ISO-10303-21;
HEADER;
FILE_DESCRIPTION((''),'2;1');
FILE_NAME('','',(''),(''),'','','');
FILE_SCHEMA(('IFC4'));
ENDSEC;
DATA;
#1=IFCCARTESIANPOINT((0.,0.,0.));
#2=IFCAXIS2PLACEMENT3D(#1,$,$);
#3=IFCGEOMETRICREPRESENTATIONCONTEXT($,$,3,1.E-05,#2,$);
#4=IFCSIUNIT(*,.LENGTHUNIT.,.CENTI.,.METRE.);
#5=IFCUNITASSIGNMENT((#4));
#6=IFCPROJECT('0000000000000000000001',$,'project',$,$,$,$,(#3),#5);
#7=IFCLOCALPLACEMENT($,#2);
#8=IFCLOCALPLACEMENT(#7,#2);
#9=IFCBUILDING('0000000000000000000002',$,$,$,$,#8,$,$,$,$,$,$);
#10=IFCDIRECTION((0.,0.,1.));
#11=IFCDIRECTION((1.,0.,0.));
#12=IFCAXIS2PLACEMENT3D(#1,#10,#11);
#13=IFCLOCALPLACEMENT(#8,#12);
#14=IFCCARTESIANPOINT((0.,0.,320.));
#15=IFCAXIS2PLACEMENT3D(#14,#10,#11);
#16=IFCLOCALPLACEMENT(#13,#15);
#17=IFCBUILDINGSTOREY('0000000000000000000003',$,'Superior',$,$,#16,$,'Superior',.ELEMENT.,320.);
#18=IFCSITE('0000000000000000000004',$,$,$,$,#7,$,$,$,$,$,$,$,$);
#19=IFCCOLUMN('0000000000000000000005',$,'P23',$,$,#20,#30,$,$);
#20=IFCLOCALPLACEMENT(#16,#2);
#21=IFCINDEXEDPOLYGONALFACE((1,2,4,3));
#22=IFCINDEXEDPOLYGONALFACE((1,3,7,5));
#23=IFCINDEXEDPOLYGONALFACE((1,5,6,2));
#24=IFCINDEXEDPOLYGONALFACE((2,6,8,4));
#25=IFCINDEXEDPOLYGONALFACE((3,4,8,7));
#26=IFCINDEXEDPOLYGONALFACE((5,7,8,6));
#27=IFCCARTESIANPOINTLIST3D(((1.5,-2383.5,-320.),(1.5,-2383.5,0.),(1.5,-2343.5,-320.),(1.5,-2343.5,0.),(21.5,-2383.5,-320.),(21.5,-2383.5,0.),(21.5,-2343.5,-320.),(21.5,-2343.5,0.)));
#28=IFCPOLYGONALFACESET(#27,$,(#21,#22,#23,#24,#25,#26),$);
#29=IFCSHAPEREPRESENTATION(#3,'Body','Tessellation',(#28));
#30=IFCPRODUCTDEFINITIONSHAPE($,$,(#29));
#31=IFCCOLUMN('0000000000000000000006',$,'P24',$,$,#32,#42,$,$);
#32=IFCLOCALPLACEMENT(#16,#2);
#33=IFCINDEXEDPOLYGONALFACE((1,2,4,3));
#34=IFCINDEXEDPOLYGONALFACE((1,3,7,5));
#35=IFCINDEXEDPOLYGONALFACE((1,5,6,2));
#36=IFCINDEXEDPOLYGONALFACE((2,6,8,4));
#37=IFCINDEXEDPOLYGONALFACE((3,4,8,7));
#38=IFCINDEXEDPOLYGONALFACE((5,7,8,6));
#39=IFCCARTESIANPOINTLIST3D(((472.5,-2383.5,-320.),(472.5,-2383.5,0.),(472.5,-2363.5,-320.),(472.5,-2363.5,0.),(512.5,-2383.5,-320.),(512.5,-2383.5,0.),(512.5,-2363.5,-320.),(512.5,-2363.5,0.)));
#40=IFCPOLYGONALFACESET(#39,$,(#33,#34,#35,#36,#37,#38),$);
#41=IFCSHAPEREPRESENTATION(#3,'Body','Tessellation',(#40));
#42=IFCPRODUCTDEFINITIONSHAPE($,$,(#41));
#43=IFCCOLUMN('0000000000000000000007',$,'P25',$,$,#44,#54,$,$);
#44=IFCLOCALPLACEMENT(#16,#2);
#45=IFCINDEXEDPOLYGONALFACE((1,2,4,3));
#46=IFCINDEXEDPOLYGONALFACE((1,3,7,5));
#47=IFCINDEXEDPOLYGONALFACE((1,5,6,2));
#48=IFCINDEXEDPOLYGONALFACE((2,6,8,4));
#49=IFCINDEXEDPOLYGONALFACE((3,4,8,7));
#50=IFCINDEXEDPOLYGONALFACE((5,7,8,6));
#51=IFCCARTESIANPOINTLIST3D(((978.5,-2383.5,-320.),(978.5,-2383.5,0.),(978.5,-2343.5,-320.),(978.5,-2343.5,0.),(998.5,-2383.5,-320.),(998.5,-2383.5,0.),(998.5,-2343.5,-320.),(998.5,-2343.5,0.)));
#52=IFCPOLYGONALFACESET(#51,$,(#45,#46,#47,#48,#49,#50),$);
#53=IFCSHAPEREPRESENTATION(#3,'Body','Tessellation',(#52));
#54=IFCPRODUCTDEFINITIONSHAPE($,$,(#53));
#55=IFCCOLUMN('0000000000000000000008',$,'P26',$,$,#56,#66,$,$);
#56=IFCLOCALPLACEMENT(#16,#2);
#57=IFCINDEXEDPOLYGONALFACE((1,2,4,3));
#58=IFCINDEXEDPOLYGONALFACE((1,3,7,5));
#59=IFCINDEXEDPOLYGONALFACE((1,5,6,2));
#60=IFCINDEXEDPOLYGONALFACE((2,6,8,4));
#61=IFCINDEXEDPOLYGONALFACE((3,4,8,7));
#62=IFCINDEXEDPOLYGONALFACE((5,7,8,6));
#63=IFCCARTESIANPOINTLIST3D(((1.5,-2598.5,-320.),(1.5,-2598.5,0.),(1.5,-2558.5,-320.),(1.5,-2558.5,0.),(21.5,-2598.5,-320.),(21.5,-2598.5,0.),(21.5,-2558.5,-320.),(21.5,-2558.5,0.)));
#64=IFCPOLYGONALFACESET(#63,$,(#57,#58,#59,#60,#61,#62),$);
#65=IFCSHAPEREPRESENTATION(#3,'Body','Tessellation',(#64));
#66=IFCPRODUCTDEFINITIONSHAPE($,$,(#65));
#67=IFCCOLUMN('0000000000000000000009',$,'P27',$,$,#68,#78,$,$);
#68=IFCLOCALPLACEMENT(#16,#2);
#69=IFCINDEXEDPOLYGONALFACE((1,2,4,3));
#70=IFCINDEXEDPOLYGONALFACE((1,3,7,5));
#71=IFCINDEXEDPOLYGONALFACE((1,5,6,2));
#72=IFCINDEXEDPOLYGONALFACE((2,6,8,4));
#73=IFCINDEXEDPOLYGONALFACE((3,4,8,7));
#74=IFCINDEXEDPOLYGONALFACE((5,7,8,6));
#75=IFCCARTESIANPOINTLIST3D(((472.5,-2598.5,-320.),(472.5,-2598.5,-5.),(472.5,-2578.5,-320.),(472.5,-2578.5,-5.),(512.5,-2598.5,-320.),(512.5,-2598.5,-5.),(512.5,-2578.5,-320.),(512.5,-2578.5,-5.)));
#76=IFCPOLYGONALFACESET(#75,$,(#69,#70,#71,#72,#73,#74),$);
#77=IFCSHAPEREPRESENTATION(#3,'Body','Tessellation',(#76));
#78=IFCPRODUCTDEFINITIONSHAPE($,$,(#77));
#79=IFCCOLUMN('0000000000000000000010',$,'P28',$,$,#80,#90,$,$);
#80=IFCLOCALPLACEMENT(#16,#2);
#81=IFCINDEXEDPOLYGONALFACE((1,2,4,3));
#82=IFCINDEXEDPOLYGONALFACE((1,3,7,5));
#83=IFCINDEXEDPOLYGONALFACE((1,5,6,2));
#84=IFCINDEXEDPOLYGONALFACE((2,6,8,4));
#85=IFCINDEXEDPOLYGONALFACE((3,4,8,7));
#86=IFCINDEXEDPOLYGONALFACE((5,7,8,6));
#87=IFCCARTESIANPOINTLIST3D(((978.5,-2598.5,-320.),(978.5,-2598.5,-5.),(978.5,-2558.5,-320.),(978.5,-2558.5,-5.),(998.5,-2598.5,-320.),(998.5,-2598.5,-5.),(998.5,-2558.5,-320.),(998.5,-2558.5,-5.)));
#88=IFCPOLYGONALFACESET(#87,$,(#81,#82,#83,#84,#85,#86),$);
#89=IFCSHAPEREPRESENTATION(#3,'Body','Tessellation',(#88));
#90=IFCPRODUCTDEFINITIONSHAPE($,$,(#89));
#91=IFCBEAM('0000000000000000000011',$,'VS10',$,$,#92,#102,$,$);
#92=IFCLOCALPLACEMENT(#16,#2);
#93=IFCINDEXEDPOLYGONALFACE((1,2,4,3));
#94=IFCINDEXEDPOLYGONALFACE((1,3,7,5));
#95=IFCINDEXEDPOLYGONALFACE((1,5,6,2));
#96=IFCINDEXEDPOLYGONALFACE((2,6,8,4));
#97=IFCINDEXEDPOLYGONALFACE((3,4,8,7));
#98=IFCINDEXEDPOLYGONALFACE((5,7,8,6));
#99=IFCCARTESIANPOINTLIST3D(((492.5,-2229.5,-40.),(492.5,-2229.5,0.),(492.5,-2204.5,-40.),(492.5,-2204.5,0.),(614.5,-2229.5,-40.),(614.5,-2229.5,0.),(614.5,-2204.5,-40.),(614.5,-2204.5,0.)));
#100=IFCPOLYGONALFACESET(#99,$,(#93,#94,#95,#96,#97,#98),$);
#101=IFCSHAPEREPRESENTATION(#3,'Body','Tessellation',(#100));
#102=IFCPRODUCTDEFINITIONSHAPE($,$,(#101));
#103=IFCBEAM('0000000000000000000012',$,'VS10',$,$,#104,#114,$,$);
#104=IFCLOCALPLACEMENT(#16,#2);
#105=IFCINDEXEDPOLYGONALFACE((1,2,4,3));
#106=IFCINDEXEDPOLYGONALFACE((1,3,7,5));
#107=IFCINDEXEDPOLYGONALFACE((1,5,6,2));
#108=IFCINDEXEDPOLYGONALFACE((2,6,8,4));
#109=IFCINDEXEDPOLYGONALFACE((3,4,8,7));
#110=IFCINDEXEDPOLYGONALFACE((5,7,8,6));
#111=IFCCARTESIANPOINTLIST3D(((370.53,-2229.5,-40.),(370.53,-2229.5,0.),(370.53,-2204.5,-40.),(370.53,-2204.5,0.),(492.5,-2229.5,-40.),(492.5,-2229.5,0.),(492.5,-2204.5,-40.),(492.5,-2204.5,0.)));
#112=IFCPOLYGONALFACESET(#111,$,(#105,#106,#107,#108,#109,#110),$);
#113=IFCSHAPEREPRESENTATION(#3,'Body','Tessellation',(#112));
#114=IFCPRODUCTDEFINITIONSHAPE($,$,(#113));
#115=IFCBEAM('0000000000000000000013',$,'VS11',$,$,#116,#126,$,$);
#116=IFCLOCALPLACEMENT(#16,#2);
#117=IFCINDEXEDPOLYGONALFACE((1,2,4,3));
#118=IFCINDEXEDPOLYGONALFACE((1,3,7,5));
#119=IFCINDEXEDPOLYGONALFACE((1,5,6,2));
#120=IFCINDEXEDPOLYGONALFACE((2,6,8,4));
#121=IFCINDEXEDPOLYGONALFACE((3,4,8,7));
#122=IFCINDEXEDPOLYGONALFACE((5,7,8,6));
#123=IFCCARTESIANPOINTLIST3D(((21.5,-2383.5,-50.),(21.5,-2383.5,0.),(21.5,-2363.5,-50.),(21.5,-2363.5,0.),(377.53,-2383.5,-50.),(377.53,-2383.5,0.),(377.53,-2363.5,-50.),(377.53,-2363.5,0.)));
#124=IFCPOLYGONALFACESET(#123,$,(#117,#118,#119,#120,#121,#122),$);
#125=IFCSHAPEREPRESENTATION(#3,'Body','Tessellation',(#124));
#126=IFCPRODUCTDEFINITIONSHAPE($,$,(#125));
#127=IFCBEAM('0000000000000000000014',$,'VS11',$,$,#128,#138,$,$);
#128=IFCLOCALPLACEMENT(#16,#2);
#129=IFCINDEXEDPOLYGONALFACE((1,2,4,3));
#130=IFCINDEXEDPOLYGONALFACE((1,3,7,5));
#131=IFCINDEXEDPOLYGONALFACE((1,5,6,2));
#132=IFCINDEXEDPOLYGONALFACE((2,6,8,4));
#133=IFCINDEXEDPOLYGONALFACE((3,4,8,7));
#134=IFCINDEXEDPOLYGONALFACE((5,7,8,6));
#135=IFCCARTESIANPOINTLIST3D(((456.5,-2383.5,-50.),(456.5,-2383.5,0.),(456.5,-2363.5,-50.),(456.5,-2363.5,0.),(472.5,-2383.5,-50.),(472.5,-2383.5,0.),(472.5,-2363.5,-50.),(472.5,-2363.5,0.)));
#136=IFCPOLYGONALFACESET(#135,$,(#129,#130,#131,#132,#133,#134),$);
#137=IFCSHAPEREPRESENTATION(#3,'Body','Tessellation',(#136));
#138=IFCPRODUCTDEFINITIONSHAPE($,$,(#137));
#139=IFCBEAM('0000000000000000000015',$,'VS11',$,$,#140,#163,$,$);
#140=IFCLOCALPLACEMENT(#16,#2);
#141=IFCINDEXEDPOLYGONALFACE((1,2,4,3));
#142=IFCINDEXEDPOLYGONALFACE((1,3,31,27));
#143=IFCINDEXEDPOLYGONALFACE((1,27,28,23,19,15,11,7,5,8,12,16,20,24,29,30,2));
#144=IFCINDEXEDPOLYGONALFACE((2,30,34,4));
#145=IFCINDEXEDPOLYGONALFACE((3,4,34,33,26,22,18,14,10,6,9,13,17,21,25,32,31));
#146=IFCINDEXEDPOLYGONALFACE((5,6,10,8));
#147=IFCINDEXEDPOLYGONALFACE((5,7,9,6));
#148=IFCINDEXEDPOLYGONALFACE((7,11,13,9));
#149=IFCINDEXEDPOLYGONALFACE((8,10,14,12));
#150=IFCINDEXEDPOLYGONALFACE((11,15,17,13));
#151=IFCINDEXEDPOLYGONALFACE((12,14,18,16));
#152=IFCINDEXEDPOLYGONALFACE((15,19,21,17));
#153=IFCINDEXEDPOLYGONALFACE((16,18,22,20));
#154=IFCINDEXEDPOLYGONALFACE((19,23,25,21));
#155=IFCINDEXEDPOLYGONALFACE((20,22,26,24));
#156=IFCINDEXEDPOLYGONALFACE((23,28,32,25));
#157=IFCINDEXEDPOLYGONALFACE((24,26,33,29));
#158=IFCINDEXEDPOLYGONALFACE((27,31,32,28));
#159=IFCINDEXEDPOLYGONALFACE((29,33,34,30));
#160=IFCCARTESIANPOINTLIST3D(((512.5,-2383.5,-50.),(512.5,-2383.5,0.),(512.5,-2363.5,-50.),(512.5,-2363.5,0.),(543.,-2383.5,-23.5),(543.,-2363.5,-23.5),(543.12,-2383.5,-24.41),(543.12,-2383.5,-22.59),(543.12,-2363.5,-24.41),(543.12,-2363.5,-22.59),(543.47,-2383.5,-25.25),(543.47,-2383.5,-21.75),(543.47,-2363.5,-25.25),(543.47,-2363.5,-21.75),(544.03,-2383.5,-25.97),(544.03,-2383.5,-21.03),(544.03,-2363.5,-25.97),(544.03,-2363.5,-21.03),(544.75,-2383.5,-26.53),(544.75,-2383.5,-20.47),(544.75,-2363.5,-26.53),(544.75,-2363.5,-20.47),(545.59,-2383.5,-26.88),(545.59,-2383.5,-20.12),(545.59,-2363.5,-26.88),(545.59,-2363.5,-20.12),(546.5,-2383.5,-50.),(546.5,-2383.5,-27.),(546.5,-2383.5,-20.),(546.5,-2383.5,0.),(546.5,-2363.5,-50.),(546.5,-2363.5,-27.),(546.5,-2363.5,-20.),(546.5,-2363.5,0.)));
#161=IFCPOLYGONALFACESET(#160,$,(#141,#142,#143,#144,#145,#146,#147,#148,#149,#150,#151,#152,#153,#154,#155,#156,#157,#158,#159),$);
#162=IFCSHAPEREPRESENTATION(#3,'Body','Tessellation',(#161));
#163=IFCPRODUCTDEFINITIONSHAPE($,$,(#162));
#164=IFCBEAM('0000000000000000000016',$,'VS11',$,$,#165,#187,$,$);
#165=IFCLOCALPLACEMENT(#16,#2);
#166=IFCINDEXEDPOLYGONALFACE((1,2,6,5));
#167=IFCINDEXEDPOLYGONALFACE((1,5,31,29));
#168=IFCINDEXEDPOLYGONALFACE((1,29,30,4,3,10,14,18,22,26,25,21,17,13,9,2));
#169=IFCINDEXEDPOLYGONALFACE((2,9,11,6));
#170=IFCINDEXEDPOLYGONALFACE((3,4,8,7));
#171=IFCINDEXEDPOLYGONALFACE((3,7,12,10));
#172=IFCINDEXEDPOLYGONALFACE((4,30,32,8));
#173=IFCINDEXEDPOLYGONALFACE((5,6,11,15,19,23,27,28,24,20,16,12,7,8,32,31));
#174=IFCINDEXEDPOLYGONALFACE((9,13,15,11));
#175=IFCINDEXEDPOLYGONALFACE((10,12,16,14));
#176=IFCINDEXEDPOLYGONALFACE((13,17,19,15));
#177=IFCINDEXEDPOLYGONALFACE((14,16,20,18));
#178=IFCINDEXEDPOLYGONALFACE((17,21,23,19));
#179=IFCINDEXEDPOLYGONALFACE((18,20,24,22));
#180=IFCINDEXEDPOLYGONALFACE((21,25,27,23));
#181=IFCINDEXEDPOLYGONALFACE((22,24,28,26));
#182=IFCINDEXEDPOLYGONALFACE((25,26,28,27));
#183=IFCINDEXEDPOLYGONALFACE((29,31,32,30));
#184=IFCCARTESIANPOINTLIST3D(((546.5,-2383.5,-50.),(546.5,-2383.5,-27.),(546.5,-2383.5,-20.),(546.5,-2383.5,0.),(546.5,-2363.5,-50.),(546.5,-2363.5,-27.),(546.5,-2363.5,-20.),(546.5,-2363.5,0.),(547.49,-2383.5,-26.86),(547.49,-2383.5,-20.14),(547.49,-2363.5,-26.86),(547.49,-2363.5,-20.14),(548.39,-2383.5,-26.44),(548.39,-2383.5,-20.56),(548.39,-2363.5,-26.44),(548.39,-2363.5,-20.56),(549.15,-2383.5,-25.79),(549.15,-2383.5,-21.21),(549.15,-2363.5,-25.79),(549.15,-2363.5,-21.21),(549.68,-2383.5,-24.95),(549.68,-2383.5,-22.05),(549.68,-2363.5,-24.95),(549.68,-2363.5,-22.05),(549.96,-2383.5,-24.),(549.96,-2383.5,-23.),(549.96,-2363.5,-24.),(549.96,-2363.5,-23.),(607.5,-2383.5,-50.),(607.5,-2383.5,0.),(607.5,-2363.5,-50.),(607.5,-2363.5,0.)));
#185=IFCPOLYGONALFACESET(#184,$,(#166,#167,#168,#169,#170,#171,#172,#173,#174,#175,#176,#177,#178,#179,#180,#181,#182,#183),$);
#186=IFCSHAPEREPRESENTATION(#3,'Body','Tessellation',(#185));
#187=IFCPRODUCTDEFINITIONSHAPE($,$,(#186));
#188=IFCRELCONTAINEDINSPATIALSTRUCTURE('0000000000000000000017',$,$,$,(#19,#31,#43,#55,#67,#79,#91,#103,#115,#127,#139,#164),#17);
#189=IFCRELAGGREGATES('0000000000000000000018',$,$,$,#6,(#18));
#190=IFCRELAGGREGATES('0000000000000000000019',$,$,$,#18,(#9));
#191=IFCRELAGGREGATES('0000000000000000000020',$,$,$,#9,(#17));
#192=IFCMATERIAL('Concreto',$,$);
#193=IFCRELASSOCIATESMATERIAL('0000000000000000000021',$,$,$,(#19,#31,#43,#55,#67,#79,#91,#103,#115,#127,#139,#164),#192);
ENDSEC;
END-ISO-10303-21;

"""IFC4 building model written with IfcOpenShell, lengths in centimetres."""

from ifc_helpers import new_model, si_unit, frame, origin, origin_with_axes, origin_2d_with_axis, place, context, project, spatial, polyline, circle, outline, extrude, material, element, save


model = new_model("IFC4")

# Units and contexts
context_of_model = context(None, 3, precision=1e-05, world=origin())
ifc_project = project(units=[si_unit("LENGTHUNIT", "METRE", prefix="CENTI")], contexts=[context_of_model])

# Site, building, storey
site_placement = place(None, origin())
site = spatial("IfcSite", under=ifc_project, at=site_placement)
building_placement = place(site_placement, origin())
building = spatial("IfcBuilding", under=site, at=building_placement)
placement = place(building_placement, origin_with_axes())
storey_placement = place(placement, frame((0.0, 0.0, 320.0), z_axis=(0.0, 0.0, 1.0), x_axis=(1.0, 0.0, 0.0)))
storey = spatial("IfcBuildingStorey", under=building, at=storey_placement, Name="Superior", LongName="Superior", CompositionType="ELEMENT", Elevation=320.0)

# Columns
ifc_material = material(Name="Concreto")
column_1_placement = place(storey_placement, frame((11.5, -2363.5, 0.0), z_axis=(0.0, 0.0, 1.0), x_axis=(1.0, 0.0, 0.0)))
element("IfcColumn", 1, at=column_1_placement, inside=storey, material=ifc_material, Name="P23", context=context_of_model, shape_type="SolidModel", body=[
    extrude(outline(polyline([(-10.0, -20.0), (10.0, -20.0), (10.0, 20.0), (-10.0, 20.0), (-10.0, -20.0)])), frame((0.0, 0.0, 0.0), z_axis=(0.0, 0.0, 1.0), x_axis=(1.0, 0.0, 0.0)), (0.0, 0.0, -1.0), 320.0),
])
column_2_placement = place(storey_placement, frame((492.5, -2373.5, 0.0), z_axis=(0.0, 0.0, 1.0), x_axis=(1.0, 0.0, 0.0)))
element("IfcColumn", 2, at=column_2_placement, inside=storey, material=ifc_material, Name="P24", context=context_of_model, shape_type="SolidModel", body=[
    extrude(outline(polyline([(-20.0, 10.0), (-20.0, -10.0), (20.0, -10.0), (20.0, 10.0), (-20.0, 10.0)])), origin_with_axes(), (0.0, 0.0, -1.0), 320.0),
])
column_3_placement = place(storey_placement, frame((988.5, -2363.5, 0.0), z_axis=(0.0, 0.0, 1.0), x_axis=(1.0, 0.0, 0.0)))
element("IfcColumn", 3, at=column_3_placement, inside=storey, material=ifc_material, Name="P25", context=context_of_model, shape_type="SolidModel", body=[
    extrude(outline(polyline([(10.0, 20.0), (-10.0, 20.0), (-10.0, -20.0), (10.0, -20.0), (10.0, 20.0)])), origin_with_axes(), (0.0, 0.0, -1.0), 320.0),
])
column_4_placement = place(storey_placement, frame((11.5, -2578.5, 0.0), z_axis=(0.0, 0.0, 1.0), x_axis=(1.0, 0.0, 0.0)))
element("IfcColumn", 4, at=column_4_placement, inside=storey, material=ifc_material, Name="P26", context=context_of_model, shape_type="SolidModel", body=[
    extrude(outline(polyline([(-10.0, -20.0), (10.0, -20.0), (10.0, 20.0), (-10.0, 20.0), (-10.0, -20.0)])), frame((0.0, 0.0, 0.0), z_axis=(0.0, 0.0, 1.0), x_axis=(1.0, 0.0, 0.0)), (0.0, 0.0, -1.0), 320.0),
])
column_5_placement = place(storey_placement, frame((492.5, -2588.5, -5.0), z_axis=(0.0, 0.0, 1.0), x_axis=(1.0, 0.0, 0.0)))
element("IfcColumn", 5, at=column_5_placement, inside=storey, material=ifc_material, Name="P27", context=context_of_model, shape_type="SolidModel", body=[
    extrude(outline(polyline([(20.0, -10.0), (20.0, 10.0), (-20.0, 10.0), (-20.0, -10.0), (20.0, -10.0)])), origin_with_axes(), (0.0, 0.0, -1.0), 315.0),
])
column_6_placement = place(storey_placement, frame((988.5, -2578.5, -5.0), z_axis=(0.0, 0.0, 1.0), x_axis=(1.0, 0.0, 0.0)))
element("IfcColumn", 6, at=column_6_placement, inside=storey, material=ifc_material, Name="P28", context=context_of_model, shape_type="SolidModel", body=[
    extrude(outline(polyline([(10.0, 20.0), (-10.0, 20.0), (-10.0, -20.0), (10.0, -20.0), (10.0, 20.0)])), origin_with_axes(), (0.0, 0.0, -1.0), 315.0),
])

# Beams
beam_1_placement = place(storey_placement, frame((553.5, -2217.0, 0.0), z_axis=(0.0, 0.0, 1.0), x_axis=(1.0, 0.0, 0.0)))
element("IfcBeam", 7, at=beam_1_placement, inside=storey, material=ifc_material, Name="VS10", context=context_of_model, shape_type="SolidModel", body=[
    extrude(outline(polyline([(-12.5, -20.0), (12.5, -20.0), (12.5, 20.0), (-12.5, 20.0), (-12.5, -20.0)])), frame((-61.0, 0.0, -20.0), z_axis=(1.0, 0.0, 0.0), x_axis=(0.0, -1.0, 0.0)), (0.0, 0.0, 1.0), 122.0),
])
beam_2_placement = place(storey_placement, frame((431.51, -2217.0, 0.0), z_axis=(0.0, 0.0, 1.0), x_axis=(1.0, 0.0, 0.0)))
element("IfcBeam", 8, at=beam_2_placement, inside=storey, material=ifc_material, Name="VS10", context=context_of_model, shape_type="SolidModel", body=[
    extrude(outline(polyline([(-12.5, -20.0), (12.5, -20.0), (12.5, 20.0), (-12.5, 20.0), (-12.5, -20.0)])), frame((-60.98, 0.0, -20.0), z_axis=(1.0, 0.0, 0.0), x_axis=(0.0, -1.0, 0.0)), (0.0, 0.0, 1.0), 121.97),
])
beam_3_placement = place(storey_placement, frame((199.51, -2373.5, 0.0), z_axis=(0.0, 0.0, 1.0), x_axis=(1.0, 0.0, 0.0)))
element("IfcBeam", 9, at=beam_3_placement, inside=storey, material=ifc_material, Name="VS11", context=context_of_model, shape_type="SolidModel", body=[
    extrude(outline(polyline([(-10.0, -25.0), (10.0, -25.0), (10.0, 25.0), (-10.0, 25.0), (-10.0, -25.0)])), frame((-178.01, 0.0, -25.0), z_axis=(1.0, 0.0, 0.0), x_axis=(0.0, -1.0, 0.0)), (0.0, 0.0, 1.0), 356.03),
])
beam_4_placement = place(storey_placement, frame((464.5, -2373.5, 0.0), z_axis=(0.0, 0.0, 1.0), x_axis=(1.0, 0.0, 0.0)))
element("IfcBeam", 10, at=beam_4_placement, inside=storey, material=ifc_material, Name="VS11", context=context_of_model, shape_type="SolidModel", body=[
    extrude(outline(polyline([(-10.0, -25.0), (10.0, -25.0), (10.0, 25.0), (-10.0, 25.0), (-10.0, -25.0)])), frame((-8.0, 0.0, -25.0), z_axis=(1.0, 0.0, 0.0), x_axis=(0.0, -1.0, 0.0)), (0.0, 0.0, 1.0), 16.0),
])

# Beams, openings
beam_5_placement = place(storey_placement, frame((529.5, -2373.5, 0.0), z_axis=(0.0, 0.0, 1.0), x_axis=(1.0, 0.0, 0.0)))
beam_5 = element("IfcBeam", 11, at=beam_5_placement, inside=storey, material=ifc_material, Name="VS11", context=context_of_model, shape_type="SolidModel", body=[
    extrude(outline(polyline([(-10.0, -25.0), (10.0, -25.0), (10.0, 25.0), (-10.0, 25.0), (-10.0, -25.0)])), frame((-17.0, 0.0, -25.0), z_axis=(1.0, 0.0, 0.0), x_axis=(0.0, -1.0, 0.0)), (0.0, 0.0, 1.0), 34.0),
])
opening_1_placement = place(storey_placement, frame((0.0, 0.0, -320.0), z_axis=(0.0, 0.0, 1.0), x_axis=(1.0, 0.0, 0.0)))
element("IfcOpeningElement", 12, at=opening_1_placement, cuts=beam_5, material=ifc_material, context=context_of_model, shape_type="SweptSolid", body=[
    extrude(circle(Radius=3.5, at=origin_2d_with_axis()), frame((546.5, -2383.5, 296.5), z_axis=(0.0, 1.0, 0.0), x_axis=(-1.0, 0.0, 0.0)), (0.0, 0.0, 1.0), 20.0),
])
beam_6_placement = place(storey_placement, frame((577.0, -2373.5, 0.0), z_axis=(0.0, 0.0, 1.0), x_axis=(1.0, 0.0, 0.0)))
beam_6 = element("IfcBeam", 13, at=beam_6_placement, inside=storey, material=ifc_material, Name="VS11", context=context_of_model, shape_type="SolidModel", body=[
    extrude(outline(polyline([(-10.0, -25.0), (10.0, -25.0), (10.0, 25.0), (-10.0, 25.0), (-10.0, -25.0)])), frame((-30.5, 0.0, -25.0), z_axis=(1.0, 0.0, 0.0), x_axis=(0.0, -1.0, 0.0)), (0.0, 0.0, 1.0), 61.0),
])
opening_2_placement = place(storey_placement, frame((0.0, 0.0, -320.0), z_axis=(0.0, 0.0, 1.0), x_axis=(1.0, 0.0, 0.0)))
element("IfcOpeningElement", 14, at=opening_2_placement, cuts=beam_6, material=ifc_material, context=context_of_model, shape_type="SweptSolid", body=[
    extrude(circle(Radius=3.5, at=origin_2d_with_axis()), frame((546.5, -2383.5, 296.5), z_axis=(0.0, 1.0, 0.0), x_axis=(-1.0, 0.0, 0.0)), (0.0, 0.0, 1.0), 20.0),
])

save(model, "model.ifc")
